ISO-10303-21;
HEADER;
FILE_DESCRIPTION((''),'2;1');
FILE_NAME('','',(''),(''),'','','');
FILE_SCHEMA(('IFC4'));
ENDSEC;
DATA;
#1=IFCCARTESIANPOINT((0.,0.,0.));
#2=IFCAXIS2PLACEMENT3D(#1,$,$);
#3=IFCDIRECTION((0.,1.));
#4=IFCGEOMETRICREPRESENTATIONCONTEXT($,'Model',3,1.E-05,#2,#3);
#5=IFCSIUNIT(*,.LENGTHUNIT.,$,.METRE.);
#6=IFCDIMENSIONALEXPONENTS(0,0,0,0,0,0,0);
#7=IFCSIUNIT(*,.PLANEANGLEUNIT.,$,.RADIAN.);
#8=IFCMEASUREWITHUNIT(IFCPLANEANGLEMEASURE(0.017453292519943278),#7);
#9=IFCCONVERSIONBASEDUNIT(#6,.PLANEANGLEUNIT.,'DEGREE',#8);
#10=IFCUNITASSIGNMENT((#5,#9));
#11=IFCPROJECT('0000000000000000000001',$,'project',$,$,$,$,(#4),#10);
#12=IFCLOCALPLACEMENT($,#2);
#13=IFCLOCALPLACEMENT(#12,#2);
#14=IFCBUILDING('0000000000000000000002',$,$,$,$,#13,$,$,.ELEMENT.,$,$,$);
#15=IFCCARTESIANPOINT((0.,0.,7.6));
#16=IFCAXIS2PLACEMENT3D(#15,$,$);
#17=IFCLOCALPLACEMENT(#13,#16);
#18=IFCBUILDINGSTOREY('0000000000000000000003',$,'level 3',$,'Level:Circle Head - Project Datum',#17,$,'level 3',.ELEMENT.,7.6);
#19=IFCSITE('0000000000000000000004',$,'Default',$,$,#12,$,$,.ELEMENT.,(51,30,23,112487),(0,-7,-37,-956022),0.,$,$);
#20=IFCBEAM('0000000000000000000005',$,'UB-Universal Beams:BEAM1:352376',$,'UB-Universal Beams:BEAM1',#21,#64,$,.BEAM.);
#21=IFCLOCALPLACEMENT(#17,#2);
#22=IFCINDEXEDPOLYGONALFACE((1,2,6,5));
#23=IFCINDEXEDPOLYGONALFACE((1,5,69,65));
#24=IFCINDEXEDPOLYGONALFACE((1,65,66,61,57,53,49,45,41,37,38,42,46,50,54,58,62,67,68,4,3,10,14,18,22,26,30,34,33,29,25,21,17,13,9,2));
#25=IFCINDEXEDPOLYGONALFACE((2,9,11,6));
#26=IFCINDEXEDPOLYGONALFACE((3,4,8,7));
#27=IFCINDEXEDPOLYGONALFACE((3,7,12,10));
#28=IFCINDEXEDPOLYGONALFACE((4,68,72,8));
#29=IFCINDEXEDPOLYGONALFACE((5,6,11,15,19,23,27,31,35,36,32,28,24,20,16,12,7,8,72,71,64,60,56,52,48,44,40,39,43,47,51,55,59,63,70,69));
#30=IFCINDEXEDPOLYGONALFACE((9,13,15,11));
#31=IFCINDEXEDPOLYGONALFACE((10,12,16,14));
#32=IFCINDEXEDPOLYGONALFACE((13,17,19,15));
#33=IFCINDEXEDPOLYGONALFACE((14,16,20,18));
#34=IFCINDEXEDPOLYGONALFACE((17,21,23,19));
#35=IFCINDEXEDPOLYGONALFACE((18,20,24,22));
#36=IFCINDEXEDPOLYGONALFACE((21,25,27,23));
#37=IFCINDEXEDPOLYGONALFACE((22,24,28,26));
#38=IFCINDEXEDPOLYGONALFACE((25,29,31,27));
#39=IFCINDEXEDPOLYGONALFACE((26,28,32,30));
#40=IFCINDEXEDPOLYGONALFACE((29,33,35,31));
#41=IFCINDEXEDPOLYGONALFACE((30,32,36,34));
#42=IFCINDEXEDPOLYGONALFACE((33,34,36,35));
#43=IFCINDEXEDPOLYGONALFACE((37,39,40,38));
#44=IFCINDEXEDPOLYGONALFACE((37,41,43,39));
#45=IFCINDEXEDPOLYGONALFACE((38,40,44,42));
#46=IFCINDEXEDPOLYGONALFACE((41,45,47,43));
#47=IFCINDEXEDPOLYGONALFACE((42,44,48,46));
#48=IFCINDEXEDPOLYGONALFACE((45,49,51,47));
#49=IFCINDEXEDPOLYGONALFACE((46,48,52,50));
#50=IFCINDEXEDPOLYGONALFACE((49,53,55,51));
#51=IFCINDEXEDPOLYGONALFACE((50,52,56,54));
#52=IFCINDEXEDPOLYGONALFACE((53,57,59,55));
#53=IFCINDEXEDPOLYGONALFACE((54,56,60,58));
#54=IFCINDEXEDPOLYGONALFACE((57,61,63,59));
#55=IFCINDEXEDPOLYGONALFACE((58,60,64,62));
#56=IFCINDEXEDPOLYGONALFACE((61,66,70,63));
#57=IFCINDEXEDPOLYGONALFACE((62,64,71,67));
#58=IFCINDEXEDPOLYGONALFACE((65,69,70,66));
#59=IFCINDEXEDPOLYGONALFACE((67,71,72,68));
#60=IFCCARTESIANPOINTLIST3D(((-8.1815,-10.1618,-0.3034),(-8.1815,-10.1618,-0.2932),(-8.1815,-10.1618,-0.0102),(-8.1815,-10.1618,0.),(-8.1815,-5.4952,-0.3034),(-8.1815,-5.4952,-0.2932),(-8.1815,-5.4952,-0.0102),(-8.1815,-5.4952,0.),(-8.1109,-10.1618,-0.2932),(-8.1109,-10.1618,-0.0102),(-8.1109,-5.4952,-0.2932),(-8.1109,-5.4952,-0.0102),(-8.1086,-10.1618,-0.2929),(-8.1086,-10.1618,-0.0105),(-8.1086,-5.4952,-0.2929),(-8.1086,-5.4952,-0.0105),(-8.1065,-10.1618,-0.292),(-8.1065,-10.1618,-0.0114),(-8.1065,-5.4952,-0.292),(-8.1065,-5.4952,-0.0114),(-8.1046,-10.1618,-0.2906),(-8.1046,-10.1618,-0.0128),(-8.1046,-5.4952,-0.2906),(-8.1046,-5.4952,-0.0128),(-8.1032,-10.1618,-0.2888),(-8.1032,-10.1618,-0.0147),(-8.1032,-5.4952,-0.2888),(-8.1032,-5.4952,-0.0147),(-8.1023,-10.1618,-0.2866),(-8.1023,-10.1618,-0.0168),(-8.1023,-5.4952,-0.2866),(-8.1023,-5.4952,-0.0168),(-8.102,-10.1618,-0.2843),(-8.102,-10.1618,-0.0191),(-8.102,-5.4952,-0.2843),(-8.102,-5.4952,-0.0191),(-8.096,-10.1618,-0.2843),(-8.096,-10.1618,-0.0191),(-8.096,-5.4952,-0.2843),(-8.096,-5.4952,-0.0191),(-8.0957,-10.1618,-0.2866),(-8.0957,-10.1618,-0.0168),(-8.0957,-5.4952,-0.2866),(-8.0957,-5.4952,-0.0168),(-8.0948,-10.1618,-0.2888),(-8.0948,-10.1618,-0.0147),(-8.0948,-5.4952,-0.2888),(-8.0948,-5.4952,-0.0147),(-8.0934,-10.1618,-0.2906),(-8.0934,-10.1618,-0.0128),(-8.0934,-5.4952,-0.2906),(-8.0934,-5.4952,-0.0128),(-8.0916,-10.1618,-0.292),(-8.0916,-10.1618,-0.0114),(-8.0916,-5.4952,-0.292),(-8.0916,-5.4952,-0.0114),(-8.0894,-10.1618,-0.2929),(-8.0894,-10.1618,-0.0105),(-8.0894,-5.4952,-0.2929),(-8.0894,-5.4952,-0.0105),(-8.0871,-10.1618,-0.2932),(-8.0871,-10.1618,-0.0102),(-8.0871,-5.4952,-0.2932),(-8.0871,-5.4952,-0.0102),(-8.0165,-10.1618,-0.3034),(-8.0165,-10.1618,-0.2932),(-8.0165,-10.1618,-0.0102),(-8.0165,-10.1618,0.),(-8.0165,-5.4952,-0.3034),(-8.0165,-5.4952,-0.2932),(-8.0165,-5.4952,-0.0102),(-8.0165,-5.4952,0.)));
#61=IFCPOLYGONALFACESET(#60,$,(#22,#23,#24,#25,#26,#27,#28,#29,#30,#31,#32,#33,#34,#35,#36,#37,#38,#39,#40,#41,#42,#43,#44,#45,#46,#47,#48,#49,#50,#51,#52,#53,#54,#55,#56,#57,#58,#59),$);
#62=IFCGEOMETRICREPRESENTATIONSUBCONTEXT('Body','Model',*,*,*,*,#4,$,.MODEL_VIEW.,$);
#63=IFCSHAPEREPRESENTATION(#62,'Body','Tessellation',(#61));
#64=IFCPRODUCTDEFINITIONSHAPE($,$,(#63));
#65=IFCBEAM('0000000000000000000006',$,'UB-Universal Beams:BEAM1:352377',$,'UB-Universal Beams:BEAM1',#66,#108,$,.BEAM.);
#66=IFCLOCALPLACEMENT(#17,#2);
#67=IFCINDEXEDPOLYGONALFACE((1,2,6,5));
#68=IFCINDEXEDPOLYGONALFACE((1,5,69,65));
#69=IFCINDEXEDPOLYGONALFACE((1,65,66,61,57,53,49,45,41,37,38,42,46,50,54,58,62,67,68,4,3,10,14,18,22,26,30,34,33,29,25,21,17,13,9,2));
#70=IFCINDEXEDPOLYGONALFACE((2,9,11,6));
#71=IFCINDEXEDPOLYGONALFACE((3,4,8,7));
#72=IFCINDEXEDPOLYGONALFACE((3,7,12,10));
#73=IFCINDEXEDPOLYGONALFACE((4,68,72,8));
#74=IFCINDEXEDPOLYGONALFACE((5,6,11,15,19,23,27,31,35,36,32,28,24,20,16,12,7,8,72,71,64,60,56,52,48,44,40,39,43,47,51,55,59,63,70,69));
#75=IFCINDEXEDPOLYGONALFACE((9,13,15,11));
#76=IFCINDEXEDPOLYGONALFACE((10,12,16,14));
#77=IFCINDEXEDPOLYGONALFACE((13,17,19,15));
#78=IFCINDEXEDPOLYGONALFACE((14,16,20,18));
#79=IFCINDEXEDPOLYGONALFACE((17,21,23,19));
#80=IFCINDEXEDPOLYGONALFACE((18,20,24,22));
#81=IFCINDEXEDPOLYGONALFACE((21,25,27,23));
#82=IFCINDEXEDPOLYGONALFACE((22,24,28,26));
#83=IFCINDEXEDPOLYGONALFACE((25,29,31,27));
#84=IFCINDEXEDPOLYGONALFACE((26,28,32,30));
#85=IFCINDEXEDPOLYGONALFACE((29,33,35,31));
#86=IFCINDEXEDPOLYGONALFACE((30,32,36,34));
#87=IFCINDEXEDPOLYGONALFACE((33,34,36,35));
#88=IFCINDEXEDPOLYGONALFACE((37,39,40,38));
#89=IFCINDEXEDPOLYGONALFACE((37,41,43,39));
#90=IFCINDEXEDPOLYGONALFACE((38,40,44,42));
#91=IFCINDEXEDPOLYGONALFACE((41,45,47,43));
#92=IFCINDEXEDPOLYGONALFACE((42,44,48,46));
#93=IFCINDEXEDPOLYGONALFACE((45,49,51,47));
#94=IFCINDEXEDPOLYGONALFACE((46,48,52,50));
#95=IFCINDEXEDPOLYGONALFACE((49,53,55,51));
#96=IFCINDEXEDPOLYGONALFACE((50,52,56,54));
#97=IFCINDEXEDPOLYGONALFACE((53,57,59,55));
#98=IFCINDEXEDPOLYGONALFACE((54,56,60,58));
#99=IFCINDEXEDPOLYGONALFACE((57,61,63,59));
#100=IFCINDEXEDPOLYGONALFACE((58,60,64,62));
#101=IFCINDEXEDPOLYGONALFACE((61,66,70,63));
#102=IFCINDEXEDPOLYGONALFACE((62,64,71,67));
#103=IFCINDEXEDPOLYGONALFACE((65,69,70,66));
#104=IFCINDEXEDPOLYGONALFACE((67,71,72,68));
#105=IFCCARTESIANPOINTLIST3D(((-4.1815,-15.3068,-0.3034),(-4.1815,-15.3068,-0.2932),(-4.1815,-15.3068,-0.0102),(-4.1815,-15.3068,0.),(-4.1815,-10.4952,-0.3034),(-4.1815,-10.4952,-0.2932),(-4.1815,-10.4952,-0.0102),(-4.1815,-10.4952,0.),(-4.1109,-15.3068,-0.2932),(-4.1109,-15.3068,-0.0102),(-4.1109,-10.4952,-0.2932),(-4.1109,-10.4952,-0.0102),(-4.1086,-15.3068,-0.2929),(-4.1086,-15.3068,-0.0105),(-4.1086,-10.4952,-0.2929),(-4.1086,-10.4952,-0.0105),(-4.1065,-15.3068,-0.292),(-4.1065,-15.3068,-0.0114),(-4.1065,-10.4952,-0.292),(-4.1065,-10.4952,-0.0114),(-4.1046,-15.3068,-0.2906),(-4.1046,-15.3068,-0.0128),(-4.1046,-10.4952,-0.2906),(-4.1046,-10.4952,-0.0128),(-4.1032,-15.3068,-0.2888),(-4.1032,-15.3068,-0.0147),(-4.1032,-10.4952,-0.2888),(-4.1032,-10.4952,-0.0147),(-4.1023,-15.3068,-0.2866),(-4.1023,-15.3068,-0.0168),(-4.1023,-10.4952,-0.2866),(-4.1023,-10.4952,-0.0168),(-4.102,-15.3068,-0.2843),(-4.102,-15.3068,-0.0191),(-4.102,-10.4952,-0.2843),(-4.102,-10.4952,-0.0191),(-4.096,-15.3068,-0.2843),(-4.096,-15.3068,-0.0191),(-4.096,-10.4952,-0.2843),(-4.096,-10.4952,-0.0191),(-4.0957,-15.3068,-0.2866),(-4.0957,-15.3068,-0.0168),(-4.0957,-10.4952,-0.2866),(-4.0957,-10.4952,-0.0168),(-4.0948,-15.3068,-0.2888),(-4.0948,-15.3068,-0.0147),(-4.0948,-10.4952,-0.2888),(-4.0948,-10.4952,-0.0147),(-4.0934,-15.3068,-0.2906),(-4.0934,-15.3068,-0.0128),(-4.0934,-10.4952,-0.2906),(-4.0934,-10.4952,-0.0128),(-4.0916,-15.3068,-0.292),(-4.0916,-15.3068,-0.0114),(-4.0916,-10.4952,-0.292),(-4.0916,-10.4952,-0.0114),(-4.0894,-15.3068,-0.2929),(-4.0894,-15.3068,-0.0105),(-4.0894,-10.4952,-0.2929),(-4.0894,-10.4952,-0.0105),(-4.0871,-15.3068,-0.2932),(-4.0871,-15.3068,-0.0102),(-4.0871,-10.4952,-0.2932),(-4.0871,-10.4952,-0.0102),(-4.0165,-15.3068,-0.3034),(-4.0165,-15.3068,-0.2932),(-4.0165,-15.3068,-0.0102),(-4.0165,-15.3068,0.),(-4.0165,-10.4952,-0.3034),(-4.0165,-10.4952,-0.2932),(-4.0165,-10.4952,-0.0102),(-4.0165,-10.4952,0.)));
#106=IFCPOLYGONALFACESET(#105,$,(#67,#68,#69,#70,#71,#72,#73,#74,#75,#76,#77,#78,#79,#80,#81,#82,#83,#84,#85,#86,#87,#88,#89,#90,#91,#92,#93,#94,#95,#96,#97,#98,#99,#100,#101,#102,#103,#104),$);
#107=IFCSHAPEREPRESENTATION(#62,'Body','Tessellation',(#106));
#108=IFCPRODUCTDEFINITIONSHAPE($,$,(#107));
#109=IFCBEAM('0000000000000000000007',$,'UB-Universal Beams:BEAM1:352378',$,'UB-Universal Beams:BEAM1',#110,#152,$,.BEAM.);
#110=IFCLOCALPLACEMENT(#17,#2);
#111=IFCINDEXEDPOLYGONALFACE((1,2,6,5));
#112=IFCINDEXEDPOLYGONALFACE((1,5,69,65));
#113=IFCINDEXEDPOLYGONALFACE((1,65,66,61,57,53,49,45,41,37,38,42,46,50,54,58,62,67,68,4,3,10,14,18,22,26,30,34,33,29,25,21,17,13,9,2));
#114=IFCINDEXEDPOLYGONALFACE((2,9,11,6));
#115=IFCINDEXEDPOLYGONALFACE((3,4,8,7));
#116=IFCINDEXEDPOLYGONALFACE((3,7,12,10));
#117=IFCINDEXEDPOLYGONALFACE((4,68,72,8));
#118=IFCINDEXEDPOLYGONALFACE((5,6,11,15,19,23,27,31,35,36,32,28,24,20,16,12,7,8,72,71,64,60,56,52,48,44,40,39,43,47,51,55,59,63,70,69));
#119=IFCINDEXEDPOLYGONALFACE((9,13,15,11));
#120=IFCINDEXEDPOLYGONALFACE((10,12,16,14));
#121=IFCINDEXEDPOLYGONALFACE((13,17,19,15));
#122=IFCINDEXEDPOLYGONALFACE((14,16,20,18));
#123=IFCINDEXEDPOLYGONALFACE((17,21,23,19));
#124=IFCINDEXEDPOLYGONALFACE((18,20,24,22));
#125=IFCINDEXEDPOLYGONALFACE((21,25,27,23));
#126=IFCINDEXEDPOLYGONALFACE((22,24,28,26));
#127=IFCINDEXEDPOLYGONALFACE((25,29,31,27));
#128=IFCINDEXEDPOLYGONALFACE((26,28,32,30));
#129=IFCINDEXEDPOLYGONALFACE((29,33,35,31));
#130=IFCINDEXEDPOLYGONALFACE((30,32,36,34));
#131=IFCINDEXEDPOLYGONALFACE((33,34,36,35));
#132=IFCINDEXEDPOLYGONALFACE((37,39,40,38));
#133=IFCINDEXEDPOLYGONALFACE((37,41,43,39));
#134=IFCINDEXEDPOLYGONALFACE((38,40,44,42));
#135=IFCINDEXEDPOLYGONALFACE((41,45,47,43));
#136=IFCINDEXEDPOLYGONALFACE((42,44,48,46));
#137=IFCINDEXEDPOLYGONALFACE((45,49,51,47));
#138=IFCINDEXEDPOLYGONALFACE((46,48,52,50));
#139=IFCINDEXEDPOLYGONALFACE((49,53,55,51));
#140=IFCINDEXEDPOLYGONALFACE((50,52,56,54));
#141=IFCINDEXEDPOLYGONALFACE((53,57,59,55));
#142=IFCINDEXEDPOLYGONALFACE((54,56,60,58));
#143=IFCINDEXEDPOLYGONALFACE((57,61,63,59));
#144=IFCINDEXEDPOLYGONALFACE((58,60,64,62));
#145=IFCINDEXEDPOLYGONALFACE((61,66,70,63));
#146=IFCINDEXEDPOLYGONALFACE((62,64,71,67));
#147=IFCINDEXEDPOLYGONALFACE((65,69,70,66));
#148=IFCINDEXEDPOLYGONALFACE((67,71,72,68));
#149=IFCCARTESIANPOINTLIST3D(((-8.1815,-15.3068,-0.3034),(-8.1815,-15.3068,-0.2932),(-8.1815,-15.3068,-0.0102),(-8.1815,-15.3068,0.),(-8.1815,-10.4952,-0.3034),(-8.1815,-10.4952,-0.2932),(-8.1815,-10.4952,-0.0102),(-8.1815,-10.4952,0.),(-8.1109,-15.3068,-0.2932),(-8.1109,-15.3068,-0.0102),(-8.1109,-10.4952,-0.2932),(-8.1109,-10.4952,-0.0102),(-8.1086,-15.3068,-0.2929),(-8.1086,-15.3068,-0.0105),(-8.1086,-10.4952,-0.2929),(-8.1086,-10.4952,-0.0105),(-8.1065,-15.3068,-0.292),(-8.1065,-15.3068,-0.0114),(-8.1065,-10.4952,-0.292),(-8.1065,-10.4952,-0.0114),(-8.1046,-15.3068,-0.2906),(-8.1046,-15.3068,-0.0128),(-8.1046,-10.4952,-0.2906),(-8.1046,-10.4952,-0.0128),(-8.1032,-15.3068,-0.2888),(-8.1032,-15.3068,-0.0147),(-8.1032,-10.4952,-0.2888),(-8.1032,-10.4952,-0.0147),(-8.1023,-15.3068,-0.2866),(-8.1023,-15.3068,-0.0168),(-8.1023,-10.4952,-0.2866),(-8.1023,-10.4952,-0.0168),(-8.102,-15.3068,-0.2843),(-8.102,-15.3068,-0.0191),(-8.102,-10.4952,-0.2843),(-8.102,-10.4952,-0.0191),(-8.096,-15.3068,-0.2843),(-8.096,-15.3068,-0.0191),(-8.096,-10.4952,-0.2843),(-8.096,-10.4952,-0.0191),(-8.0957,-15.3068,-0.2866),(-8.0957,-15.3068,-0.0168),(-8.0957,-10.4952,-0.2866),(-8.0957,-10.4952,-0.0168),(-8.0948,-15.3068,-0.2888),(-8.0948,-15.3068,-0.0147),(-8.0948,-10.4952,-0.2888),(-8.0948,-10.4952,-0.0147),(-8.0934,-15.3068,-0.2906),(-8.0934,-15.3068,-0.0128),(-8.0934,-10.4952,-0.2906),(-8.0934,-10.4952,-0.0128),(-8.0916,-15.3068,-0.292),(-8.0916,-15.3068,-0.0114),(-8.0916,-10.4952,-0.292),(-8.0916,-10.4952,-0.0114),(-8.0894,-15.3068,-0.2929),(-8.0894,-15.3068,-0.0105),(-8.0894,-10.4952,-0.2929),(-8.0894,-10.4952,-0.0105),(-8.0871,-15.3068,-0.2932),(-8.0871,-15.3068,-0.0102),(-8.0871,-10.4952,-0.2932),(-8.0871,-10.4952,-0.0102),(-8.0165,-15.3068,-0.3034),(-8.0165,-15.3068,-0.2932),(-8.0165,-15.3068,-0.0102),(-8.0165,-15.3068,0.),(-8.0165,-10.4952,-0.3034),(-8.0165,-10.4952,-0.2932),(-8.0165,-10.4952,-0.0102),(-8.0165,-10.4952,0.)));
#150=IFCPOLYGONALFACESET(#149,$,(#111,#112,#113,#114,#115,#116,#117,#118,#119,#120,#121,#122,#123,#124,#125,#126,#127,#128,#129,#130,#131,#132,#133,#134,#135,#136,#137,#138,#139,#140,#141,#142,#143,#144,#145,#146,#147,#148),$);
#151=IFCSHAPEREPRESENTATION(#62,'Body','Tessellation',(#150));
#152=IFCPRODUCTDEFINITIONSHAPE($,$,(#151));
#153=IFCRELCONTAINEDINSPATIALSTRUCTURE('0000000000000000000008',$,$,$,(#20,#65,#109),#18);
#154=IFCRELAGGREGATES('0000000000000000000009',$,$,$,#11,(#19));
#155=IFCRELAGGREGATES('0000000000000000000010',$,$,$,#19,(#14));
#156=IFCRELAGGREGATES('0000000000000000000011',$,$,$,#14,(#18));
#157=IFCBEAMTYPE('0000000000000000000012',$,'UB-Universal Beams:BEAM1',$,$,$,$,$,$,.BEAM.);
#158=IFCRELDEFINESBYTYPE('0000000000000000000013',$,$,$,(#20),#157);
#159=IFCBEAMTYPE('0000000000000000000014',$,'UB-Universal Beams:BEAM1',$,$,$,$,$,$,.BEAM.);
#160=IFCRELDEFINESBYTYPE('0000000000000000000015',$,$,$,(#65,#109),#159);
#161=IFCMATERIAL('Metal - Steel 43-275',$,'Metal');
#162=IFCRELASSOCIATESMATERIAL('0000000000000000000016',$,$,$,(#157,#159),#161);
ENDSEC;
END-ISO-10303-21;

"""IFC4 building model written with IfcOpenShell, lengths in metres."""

from ifc_helpers import new_model, entity, si_unit, converted_unit, direction, frame, frame_2d, origin, place, context, subcontext, project, spatial, polyline, circle_curve, parameter, trimmed, segment, composite_curve, outline, extrude, source, transform, mapped, material, material_profile, profile_set, type_object, type_shapes, element, save


model = new_model("IFC4")

# Units and contexts
model_context = context("Model", 3, precision=1e-05, world=origin(), true_north=direction((0.0, 1.0)))
body_context = subcontext(model_context, "Body", "Model", "MODEL_VIEW")
ifc_project = project(units=[si_unit("LENGTHUNIT", "METRE"), converted_unit("PLANEANGLEUNIT", "DEGREE", entity("IfcPlaneAngleMeasure", 0.017453292519943278), si_unit("PLANEANGLEUNIT", "RADIAN"), dimensions=[0, 0, 0, 0, 0, 0, 0])], contexts=[model_context])

# Site, building, storey
site_placement = place(None, origin())
site = spatial("IfcSite", under=ifc_project, at=site_placement, Name="Default", CompositionType="ELEMENT", RefLatitude=(51, 30, 23, 112487), RefLongitude=(0, -7, -37, -956022), RefElevation=0.0)
building_placement = place(site_placement, origin())
building = spatial("IfcBuilding", under=site, at=building_placement, CompositionType="ELEMENT")
storey_placement = place(building_placement, frame((0.0, 0.0, 7.6)))
storey = spatial("IfcBuildingStorey", under=building, at=storey_placement, Name="level 3", ObjectType="Level:Circle Head - Project Datum", LongName="level 3", CompositionType="ELEMENT", Elevation=7.6)

# Shared definitions
ifc_material_1 = material(Name="Metal - Steel 43-275", Category="Metal")

# Beams
ifc_material_profile_1 = material_profile(ifc_material_1, outline(composite_curve([segment(polyline([(-0.0825, -0.1415), (-0.0825, -0.1517)]), True, "CONTINUOUS"), segment(polyline([(-0.0825, -0.1517), (0.0825, -0.1517)]), True, "CONTINUOUS"), segment(polyline([(0.0825, -0.1517), (0.0825, -0.1415)]), True, "CONTINUOUS"), segment(polyline([(0.0825, -0.1415), (0.0119, -0.1415)]), True, "CONTINUOUS"), segment(trimmed(circle_curve(frame_2d((0.0119, -0.1326), x_axis=(1.0, 0.0)), 0.0089), [parameter(180.0)], [parameter(270.0)], True, "PARAMETER"), False, "CONTINUOUS"), segment(polyline([(0.003, -0.1326), (0.003, 0.1326)]), True, "CONTINUOUS"), segment(trimmed(circle_curve(frame_2d((0.0119, 0.1326), x_axis=(1.0, 0.0)), 0.0089), [parameter(90.0)], [parameter(180.0)], True, "PARAMETER"), False, "CONTINUOUS"), segment(polyline([(0.0119, 0.1415), (0.0825, 0.1415)]), True, "CONTINUOUS"), segment(polyline([(0.0825, 0.1415), (0.0825, 0.1517)]), True, "CONTINUOUS"), segment(polyline([(0.0825, 0.1517), (-0.0825, 0.1517)]), True, "CONTINUOUS"), segment(polyline([(-0.0825, 0.1517), (-0.0825, 0.1415)]), True, "CONTINUOUS"), segment(polyline([(-0.0825, 0.1415), (-0.0119, 0.1415)]), True, "CONTINUOUS"), segment(trimmed(circle_curve(frame_2d((-0.0119, 0.1326), x_axis=(1.0, 0.0)), 0.0089), [parameter(360.0)], [parameter(90.0)], True, "PARAMETER"), False, "CONTINUOUS"), segment(polyline([(-0.003, 0.1326), (-0.003, -0.1326)]), True, "CONTINUOUS"), segment(trimmed(circle_curve(frame_2d((-0.0119, -0.1326), x_axis=(1.0, 0.0)), 0.0089), [parameter(270.0)], [parameter(360.0)], True, "PARAMETER"), False, "CONTINUOUS"), segment(polyline([(-0.0119, -0.1415), (-0.0825, -0.1415)]), True, "CONTINUOUS")], self_intersect=False)), Name="BEAM1")
ifc_profile_set_1 = profile_set([ifc_material_profile_1], Name="BEAM1")
beam_type_1 = type_object("IfcBeamType", Name="UB-Universal Beams:BEAM1", PredefinedType="BEAM", material=ifc_profile_set_1)
shared_shape_1 = source(origin(), body_context, "Body", "SweptSolid", [
    extrude(outline(composite_curve([segment(polyline([(-0.0825, -0.1415), (-0.0825, -0.1517)]), True, "CONTINUOUS"), segment(polyline([(-0.0825, -0.1517), (0.0825, -0.1517)]), True, "CONTINUOUS"), segment(polyline([(0.0825, -0.1517), (0.0825, -0.1415)]), True, "CONTINUOUS"), segment(polyline([(0.0825, -0.1415), (0.0119, -0.1415)]), True, "CONTINUOUS"), segment(trimmed(circle_curve(frame_2d((0.0119, -0.1326), x_axis=(0.0, -1.0)), 0.0089), [parameter(270.0)], [parameter(360.0)], True, "PARAMETER"), False, "CONTINUOUS"), segment(polyline([(0.003, -0.1326), (0.003, 0.1326)]), True, "CONTINUOUS"), segment(trimmed(circle_curve(frame_2d((0.0119, 0.1326), x_axis=(-1.0, 0.0)), 0.0089), [parameter(270.0)], [parameter(360.0)], True, "PARAMETER"), False, "CONTINUOUS"), segment(polyline([(0.0119, 0.1415), (0.0825, 0.1415)]), True, "CONTINUOUS"), segment(polyline([(0.0825, 0.1415), (0.0825, 0.1517)]), True, "CONTINUOUS"), segment(polyline([(0.0825, 0.1517), (-0.0825, 0.1517)]), True, "CONTINUOUS"), segment(polyline([(-0.0825, 0.1517), (-0.0825, 0.1415)]), True, "CONTINUOUS"), segment(polyline([(-0.0825, 0.1415), (-0.0119, 0.1415)]), True, "CONTINUOUS"), segment(trimmed(circle_curve(frame_2d((-0.0119, 0.1326), x_axis=(0.0, 1.0)), 0.0089), [parameter(270.0)], [parameter(360.0)], True, "PARAMETER"), False, "CONTINUOUS"), segment(polyline([(-0.003, 0.1326), (-0.003, -0.1326)]), True, "CONTINUOUS"), segment(trimmed(circle_curve(frame_2d((-0.0119, -0.1326), x_axis=(1.0, 0.0)), 0.0089), [parameter(270.0)], [parameter(0.0)], True, "PARAMETER"), False, "CONTINUOUS"), segment(polyline([(-0.0119, -0.1415), (-0.0825, -0.1415)]), True, "CONTINUOUS")], self_intersect=False)), frame((-2.3333, 0.0, 0.0), z_axis=(-1.0, 0.0, 0.0), x_axis=(0.0, -1.0, 0.0)), (0.0, 0.0, -1.0), 4.6666),
])
type_shapes(beam_type_1, [shared_shape_1])
for number, where, z_axis, x_axis, name in (
    (1, (-8.099, -7.8285, -0.1517), (0.0, 0.0, 1.0), (0.0, 1.0, 0.0), "UB-Universal Beams:BEAM1:352376"),
):
    element("IfcBeam", number, at=place(storey_placement, frame(where, z_axis=z_axis, x_axis=x_axis)), inside=storey, type_object=beam_type_1, Name=name, ObjectType="UB-Universal Beams:BEAM1", PredefinedType="BEAM", context=body_context, shape_type="MappedRepresentation", body=[
        mapped(shared_shape_1, transform((0.0, 0.0, 0.0), scale=1.0)),
    ])
beam_type_2 = type_object("IfcBeamType", Name="UB-Universal Beams:BEAM1", PredefinedType="BEAM", material=ifc_profile_set_1)
shared_shape_2 = source(origin(), body_context, "Body", "SweptSolid", [
    extrude(outline(composite_curve([segment(polyline([(-0.0825, -0.1415), (-0.0825, -0.1517)]), True, "CONTINUOUS"), segment(polyline([(-0.0825, -0.1517), (0.0825, -0.1517)]), True, "CONTINUOUS"), segment(polyline([(0.0825, -0.1517), (0.0825, -0.1415)]), True, "CONTINUOUS"), segment(polyline([(0.0825, -0.1415), (0.0119, -0.1415)]), True, "CONTINUOUS"), segment(trimmed(circle_curve(frame_2d((0.0119, -0.1326), x_axis=(0.0, -1.0)), 0.0089), [parameter(270.0)], [parameter(360.0)], True, "PARAMETER"), False, "CONTINUOUS"), segment(polyline([(0.003, -0.1326), (0.003, 0.1326)]), True, "CONTINUOUS"), segment(trimmed(circle_curve(frame_2d((0.0119, 0.1326), x_axis=(-1.0, 0.0)), 0.0089), [parameter(270.0)], [parameter(360.0)], True, "PARAMETER"), False, "CONTINUOUS"), segment(polyline([(0.0119, 0.1415), (0.0825, 0.1415)]), True, "CONTINUOUS"), segment(polyline([(0.0825, 0.1415), (0.0825, 0.1517)]), True, "CONTINUOUS"), segment(polyline([(0.0825, 0.1517), (-0.0825, 0.1517)]), True, "CONTINUOUS"), segment(polyline([(-0.0825, 0.1517), (-0.0825, 0.1415)]), True, "CONTINUOUS"), segment(polyline([(-0.0825, 0.1415), (-0.0119, 0.1415)]), True, "CONTINUOUS"), segment(trimmed(circle_curve(frame_2d((-0.0119, 0.1326), x_axis=(0.0, 1.0)), 0.0089), [parameter(270.0)], [parameter(360.0)], True, "PARAMETER"), False, "CONTINUOUS"), segment(polyline([(-0.003, 0.1326), (-0.003, -0.1326)]), True, "CONTINUOUS"), segment(trimmed(circle_curve(frame_2d((-0.0119, -0.1326), x_axis=(1.0, 0.0)), 0.0089), [parameter(270.0)], [parameter(0.0)], True, "PARAMETER"), False, "CONTINUOUS"), segment(polyline([(-0.0119, -0.1415), (-0.0825, -0.1415)]), True, "CONTINUOUS")], self_intersect=False)), frame((-2.4058, 0.0, 0.0), z_axis=(-1.0, 0.0, 0.0), x_axis=(0.0, -1.0, 0.0)), (0.0, 0.0, -1.0), 4.8116),
])
type_shapes(beam_type_2, [shared_shape_2])
for number, where, z_axis, x_axis, name in (
    (2, (-4.099, -12.901, -0.1517), (0.0, 0.0, 1.0), (0.0, 1.0, 0.0), "UB-Universal Beams:BEAM1:352377"),
    (3, (-8.099, -12.901, -0.1517), (0.0, 0.0, 1.0), (0.0, 1.0, 0.0), "UB-Universal Beams:BEAM1:352378"),
):
    element("IfcBeam", number, at=place(storey_placement, frame(where, z_axis=z_axis, x_axis=x_axis)), inside=storey, type_object=beam_type_2, Name=name, ObjectType="UB-Universal Beams:BEAM1", PredefinedType="BEAM", context=body_context, shape_type="MappedRepresentation", body=[
        mapped(shared_shape_2, transform((0.0, 0.0, 0.0), scale=1.0)),
    ])

save(model, "model.ifc")
